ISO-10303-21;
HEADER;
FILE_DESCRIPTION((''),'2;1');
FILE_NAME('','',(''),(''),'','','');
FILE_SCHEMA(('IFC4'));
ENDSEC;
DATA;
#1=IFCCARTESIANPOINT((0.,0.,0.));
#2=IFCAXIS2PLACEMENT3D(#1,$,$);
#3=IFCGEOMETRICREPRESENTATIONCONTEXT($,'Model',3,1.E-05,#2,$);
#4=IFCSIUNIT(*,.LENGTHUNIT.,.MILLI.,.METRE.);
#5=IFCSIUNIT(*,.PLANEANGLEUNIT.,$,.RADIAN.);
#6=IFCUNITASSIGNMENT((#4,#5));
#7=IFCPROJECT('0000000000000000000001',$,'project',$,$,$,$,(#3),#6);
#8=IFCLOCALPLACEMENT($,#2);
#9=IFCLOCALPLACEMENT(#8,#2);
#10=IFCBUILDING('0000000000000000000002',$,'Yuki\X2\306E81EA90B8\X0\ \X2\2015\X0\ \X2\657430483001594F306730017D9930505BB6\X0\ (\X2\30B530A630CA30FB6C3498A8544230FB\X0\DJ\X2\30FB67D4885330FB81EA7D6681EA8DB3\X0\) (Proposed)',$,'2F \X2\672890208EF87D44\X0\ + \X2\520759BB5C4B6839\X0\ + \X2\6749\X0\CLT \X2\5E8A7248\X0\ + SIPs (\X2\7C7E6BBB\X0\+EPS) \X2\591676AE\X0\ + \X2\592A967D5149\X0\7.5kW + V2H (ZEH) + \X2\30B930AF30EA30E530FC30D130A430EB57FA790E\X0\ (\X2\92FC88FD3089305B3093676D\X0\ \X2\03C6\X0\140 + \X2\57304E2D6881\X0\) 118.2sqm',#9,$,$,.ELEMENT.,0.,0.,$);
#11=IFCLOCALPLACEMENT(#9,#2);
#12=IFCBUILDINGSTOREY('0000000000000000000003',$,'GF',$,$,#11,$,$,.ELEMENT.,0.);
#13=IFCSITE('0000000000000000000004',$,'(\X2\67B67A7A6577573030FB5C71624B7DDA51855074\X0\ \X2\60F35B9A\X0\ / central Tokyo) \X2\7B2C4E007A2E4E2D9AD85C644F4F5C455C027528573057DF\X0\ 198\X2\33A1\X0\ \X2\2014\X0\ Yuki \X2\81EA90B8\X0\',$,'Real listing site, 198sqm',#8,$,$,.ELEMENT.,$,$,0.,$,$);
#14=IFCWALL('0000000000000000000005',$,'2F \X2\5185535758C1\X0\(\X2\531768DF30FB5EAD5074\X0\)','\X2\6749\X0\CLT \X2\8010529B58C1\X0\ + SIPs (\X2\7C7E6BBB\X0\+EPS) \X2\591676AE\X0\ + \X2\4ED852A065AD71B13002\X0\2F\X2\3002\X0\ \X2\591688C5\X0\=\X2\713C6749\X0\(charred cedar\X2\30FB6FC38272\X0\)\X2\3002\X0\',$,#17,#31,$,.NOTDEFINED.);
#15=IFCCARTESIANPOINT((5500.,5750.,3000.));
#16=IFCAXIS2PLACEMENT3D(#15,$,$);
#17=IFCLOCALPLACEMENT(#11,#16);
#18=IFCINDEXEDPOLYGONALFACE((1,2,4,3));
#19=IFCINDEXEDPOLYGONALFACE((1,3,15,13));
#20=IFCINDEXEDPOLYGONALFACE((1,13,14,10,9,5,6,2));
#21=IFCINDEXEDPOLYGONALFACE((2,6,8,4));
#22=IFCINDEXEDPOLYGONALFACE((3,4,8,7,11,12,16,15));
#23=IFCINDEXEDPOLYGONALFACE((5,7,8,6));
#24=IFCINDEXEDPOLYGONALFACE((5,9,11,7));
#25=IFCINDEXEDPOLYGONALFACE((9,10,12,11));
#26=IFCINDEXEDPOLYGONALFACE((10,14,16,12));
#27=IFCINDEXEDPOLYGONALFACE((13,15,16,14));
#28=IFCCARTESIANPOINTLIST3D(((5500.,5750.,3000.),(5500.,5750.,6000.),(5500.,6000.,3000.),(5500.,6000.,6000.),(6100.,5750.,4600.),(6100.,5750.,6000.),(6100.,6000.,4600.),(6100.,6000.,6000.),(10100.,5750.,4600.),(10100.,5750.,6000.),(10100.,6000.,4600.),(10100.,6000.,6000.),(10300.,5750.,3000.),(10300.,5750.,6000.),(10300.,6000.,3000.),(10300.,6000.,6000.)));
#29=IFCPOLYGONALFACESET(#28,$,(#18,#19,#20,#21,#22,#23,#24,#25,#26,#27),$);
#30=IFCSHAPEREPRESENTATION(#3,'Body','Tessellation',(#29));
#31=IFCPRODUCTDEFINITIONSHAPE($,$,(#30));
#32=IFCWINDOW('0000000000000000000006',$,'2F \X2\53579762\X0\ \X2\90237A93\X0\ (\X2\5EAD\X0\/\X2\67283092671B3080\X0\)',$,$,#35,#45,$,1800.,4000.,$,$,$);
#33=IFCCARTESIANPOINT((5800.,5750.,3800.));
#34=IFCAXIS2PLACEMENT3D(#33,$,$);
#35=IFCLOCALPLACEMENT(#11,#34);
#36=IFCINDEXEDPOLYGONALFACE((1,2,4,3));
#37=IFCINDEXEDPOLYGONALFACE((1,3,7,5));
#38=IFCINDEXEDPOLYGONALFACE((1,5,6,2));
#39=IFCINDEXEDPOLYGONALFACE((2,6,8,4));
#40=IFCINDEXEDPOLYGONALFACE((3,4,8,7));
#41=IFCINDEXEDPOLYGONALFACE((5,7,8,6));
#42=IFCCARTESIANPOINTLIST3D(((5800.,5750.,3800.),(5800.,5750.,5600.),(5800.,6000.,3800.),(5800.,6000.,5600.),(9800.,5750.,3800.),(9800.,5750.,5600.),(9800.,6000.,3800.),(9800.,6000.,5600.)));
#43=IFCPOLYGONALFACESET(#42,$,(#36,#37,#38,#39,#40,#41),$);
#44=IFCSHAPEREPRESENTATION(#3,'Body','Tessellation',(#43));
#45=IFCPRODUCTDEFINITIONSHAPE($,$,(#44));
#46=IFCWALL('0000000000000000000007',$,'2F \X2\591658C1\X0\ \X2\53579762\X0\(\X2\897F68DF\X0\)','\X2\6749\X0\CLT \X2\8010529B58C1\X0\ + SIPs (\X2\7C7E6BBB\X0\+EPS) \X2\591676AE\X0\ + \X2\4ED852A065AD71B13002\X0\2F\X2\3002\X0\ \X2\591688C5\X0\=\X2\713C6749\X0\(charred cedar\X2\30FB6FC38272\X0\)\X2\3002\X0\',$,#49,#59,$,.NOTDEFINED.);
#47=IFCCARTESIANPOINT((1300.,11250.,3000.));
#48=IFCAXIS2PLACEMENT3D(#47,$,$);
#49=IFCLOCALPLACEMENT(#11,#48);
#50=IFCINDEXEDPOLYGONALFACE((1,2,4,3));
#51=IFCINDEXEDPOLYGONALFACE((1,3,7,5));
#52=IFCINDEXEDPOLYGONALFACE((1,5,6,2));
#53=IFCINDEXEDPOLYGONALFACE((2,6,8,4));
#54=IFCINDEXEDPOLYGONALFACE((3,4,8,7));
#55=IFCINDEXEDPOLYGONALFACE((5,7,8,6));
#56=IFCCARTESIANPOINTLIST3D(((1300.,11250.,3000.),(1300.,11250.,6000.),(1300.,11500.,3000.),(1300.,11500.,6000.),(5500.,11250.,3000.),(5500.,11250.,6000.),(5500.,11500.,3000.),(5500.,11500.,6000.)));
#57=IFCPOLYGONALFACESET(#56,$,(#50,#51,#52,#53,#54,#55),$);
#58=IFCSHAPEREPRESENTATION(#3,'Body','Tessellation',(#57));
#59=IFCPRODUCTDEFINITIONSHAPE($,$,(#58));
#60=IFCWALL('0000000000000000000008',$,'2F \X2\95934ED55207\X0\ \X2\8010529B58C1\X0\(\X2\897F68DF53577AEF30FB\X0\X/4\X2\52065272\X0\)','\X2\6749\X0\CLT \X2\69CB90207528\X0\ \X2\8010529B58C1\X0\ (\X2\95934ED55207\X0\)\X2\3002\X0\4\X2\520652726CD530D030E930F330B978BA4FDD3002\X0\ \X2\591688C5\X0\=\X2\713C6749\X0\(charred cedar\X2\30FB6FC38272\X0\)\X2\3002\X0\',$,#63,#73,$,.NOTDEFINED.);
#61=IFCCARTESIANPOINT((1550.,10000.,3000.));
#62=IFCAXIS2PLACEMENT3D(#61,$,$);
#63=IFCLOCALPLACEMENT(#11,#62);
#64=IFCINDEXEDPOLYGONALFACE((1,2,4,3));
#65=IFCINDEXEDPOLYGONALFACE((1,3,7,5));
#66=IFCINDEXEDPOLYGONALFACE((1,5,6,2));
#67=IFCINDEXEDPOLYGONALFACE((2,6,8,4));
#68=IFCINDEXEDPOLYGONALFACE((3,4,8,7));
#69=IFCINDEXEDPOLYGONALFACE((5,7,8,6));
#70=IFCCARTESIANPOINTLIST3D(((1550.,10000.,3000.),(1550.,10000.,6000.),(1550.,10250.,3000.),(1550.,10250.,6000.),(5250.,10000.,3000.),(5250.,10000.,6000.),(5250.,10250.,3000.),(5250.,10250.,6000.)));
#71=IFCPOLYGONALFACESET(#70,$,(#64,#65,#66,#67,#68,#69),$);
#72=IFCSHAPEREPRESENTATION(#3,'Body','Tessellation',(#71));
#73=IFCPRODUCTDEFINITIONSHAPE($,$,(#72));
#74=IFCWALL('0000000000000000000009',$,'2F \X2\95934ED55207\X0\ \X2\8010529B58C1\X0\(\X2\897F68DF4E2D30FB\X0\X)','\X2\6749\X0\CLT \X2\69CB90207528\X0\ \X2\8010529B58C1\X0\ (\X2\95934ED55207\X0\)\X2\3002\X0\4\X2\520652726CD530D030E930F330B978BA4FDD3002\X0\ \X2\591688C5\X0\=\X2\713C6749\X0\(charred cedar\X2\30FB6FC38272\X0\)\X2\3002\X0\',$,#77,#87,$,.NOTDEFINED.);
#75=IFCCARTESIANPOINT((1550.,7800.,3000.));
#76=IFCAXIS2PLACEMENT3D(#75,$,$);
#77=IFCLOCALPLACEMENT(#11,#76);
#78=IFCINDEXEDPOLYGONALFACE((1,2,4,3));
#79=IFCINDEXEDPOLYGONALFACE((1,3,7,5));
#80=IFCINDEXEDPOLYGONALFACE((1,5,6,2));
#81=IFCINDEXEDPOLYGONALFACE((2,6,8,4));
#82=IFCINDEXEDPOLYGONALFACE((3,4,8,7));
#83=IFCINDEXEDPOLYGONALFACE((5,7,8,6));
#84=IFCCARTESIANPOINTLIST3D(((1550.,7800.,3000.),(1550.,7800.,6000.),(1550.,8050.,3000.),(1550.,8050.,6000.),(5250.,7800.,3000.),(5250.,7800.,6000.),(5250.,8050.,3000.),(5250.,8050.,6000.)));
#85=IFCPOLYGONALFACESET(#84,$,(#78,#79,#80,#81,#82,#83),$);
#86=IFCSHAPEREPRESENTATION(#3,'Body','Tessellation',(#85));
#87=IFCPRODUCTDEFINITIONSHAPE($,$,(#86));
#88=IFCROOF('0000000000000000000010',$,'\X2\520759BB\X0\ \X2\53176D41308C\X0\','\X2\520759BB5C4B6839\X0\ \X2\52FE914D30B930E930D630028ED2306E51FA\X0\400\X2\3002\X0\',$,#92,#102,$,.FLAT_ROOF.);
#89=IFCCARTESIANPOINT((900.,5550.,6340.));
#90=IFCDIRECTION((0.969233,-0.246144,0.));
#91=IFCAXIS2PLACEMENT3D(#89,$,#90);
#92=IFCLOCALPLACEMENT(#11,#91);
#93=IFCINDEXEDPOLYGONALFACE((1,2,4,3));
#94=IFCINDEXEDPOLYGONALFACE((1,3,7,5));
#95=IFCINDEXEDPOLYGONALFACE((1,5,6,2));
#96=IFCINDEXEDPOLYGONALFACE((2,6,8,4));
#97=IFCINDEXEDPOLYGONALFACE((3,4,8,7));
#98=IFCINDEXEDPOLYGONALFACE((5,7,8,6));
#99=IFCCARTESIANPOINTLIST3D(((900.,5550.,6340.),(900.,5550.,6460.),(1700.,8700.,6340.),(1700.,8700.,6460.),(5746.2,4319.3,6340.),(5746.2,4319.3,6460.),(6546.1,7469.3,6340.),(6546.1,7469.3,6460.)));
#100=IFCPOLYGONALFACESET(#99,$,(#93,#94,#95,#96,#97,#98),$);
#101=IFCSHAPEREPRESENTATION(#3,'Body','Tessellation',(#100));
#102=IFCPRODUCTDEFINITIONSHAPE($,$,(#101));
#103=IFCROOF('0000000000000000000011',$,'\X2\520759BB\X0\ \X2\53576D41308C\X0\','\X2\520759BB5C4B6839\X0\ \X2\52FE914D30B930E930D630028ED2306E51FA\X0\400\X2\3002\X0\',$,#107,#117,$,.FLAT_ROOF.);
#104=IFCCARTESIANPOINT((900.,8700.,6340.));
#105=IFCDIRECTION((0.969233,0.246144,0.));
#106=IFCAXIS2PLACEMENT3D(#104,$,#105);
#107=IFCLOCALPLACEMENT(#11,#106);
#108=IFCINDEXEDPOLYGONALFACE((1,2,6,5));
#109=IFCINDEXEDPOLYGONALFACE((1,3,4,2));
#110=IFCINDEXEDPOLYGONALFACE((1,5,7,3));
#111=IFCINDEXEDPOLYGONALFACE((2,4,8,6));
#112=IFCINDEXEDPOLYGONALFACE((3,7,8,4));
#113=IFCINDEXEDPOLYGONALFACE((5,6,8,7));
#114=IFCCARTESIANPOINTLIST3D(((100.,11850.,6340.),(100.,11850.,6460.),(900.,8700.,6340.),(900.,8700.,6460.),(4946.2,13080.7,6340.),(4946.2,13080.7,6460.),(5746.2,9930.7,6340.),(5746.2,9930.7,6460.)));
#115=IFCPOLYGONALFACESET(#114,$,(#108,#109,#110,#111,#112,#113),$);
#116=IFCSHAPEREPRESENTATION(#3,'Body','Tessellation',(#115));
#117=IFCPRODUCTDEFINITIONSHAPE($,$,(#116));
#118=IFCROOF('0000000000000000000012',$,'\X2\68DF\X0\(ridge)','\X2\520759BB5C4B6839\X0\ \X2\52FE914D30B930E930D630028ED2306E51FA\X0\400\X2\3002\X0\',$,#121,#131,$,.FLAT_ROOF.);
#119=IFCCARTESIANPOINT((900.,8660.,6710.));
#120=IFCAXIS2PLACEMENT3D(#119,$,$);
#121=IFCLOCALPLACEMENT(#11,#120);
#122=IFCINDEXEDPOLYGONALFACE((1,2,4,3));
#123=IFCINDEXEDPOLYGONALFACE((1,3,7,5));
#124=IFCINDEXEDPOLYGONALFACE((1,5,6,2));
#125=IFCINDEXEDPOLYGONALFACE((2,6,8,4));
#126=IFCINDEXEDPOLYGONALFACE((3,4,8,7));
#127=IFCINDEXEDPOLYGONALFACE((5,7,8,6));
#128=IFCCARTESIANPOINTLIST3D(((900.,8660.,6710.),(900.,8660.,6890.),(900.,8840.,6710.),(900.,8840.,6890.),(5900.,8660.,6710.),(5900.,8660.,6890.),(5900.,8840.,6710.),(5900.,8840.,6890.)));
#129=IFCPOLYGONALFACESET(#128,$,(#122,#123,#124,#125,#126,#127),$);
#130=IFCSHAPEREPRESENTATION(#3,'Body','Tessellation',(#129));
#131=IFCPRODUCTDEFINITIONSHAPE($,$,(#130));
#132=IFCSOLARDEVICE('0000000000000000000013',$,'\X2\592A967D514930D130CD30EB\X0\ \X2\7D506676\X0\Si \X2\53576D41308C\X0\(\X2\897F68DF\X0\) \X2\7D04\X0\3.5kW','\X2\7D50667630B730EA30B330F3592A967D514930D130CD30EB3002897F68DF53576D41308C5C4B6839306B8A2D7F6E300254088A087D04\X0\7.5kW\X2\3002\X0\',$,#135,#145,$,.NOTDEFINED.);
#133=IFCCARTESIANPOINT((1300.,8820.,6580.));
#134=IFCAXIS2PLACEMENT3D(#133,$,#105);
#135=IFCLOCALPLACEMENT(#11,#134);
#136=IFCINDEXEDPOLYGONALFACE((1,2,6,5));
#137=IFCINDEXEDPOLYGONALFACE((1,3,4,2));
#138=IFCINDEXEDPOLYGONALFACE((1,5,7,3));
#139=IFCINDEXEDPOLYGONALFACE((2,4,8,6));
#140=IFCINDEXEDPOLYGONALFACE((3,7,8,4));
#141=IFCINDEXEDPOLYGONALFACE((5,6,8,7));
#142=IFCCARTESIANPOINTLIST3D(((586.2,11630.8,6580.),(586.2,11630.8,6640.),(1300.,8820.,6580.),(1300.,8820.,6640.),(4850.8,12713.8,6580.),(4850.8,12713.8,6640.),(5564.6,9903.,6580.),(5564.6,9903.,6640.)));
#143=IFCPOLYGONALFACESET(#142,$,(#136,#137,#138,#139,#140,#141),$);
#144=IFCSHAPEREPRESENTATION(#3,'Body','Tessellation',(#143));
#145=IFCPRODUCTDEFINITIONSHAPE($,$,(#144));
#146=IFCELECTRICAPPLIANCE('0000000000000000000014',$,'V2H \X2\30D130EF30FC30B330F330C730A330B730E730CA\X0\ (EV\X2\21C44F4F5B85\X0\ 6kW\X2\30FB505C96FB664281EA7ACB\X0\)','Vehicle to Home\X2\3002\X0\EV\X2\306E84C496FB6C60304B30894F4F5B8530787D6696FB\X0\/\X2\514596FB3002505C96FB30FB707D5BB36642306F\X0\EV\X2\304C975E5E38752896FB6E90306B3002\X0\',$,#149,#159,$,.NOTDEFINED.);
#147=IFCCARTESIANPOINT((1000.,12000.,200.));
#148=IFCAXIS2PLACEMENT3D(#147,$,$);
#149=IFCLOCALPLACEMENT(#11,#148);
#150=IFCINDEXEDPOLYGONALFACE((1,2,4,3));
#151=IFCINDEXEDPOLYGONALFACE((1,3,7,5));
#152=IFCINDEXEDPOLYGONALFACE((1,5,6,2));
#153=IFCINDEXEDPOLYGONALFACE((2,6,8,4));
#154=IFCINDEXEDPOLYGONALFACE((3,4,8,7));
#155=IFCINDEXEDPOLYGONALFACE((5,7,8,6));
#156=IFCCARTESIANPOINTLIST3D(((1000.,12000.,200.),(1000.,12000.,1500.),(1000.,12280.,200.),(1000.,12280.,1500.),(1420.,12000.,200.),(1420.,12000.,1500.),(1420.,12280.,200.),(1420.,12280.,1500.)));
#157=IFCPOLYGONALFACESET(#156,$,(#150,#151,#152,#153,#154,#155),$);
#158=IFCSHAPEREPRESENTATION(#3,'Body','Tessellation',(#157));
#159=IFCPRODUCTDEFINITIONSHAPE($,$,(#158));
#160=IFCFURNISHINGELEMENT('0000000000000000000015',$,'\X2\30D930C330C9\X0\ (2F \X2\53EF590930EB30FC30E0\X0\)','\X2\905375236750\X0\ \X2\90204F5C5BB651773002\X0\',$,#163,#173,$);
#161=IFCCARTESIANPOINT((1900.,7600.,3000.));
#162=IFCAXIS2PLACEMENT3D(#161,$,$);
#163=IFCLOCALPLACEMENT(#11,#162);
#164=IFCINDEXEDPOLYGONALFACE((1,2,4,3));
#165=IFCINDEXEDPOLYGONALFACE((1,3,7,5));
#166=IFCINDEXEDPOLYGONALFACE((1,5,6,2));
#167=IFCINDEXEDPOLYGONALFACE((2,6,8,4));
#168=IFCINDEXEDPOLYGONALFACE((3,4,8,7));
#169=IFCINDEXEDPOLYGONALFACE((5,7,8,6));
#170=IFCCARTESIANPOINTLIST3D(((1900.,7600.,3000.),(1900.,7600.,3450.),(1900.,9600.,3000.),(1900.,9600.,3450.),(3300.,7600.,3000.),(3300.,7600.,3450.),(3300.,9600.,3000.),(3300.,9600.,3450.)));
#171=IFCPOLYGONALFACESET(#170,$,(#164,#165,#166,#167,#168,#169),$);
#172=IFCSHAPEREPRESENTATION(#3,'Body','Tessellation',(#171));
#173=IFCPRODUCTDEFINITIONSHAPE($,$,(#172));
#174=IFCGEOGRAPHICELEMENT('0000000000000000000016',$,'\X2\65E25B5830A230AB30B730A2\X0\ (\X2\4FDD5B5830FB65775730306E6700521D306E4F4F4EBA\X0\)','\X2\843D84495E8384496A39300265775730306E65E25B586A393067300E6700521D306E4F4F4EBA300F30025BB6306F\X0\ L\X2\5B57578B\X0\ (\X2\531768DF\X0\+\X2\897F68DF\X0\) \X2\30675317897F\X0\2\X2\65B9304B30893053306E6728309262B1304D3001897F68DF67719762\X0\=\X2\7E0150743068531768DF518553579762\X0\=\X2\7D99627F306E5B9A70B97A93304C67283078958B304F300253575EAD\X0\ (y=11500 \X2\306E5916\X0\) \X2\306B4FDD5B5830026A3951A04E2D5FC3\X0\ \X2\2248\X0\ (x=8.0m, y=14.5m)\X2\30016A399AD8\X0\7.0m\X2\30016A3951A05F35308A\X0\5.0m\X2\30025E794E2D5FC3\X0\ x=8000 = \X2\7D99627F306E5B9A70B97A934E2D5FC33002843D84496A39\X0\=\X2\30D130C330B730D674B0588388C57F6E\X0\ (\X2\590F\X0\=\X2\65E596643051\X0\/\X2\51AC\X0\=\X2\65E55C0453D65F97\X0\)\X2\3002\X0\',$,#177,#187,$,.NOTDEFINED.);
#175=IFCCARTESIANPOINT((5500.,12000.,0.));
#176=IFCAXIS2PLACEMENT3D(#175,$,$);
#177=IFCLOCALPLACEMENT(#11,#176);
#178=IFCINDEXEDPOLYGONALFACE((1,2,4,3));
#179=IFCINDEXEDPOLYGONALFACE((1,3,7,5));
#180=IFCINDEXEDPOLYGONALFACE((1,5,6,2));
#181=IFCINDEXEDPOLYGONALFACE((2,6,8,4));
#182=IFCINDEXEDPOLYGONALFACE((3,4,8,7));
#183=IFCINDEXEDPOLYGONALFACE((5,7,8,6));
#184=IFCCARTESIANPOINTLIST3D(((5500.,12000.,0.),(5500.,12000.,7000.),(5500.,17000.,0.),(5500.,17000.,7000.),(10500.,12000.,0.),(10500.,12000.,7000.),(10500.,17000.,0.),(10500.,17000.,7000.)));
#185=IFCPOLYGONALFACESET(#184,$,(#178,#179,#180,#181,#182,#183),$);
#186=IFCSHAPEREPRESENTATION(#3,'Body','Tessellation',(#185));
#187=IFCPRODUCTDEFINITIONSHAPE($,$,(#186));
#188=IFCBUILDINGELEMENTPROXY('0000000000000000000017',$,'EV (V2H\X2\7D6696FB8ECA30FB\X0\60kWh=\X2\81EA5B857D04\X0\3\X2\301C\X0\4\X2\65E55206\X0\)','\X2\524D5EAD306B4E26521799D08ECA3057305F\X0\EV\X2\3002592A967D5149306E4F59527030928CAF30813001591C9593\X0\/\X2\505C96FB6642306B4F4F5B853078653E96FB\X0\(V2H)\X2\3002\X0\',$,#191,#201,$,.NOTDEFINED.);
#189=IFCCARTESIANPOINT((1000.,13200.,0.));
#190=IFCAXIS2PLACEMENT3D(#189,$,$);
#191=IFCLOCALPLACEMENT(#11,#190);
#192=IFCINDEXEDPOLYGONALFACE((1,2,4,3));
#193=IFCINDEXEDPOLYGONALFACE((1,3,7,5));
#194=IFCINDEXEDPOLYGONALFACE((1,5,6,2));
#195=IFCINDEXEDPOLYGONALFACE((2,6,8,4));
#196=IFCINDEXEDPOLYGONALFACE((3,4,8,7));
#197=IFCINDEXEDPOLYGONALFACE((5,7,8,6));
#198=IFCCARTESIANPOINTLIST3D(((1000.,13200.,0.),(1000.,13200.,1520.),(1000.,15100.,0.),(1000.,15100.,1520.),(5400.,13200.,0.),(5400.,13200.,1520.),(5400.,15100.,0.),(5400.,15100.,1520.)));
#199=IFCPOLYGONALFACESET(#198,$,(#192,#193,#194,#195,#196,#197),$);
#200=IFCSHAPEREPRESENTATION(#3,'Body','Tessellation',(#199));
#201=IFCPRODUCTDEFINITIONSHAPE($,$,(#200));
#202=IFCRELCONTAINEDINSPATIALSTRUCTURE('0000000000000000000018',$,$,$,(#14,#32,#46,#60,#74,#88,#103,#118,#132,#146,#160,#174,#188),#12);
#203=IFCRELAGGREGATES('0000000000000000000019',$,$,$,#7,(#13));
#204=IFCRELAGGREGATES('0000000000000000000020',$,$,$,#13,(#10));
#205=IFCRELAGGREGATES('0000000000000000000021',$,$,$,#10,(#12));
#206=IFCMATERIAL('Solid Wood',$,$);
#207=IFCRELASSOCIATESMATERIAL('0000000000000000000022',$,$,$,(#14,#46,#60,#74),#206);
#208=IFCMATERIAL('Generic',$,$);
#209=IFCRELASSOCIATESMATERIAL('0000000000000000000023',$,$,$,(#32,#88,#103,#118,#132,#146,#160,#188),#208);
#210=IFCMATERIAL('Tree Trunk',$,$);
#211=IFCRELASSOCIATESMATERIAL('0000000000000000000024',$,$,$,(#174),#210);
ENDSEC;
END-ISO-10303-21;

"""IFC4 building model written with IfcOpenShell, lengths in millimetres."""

from ifc_helpers import new_model, si_unit, frame, frame_2d, origin, place, context, project, spatial, rectangle, extrude, material, element, fill, save


model = new_model("IFC4")

# Units and contexts
model_context = context("Model", 3, precision=1e-05, world=origin())
ifc_project = project(units=[si_unit("LENGTHUNIT", "METRE", prefix="MILLI"), si_unit("PLANEANGLEUNIT", "RADIAN")], contexts=[model_context])

# Site, building, storey
site_placement = place(None, origin())
site = spatial("IfcSite", under=ifc_project, at=site_placement, Name="(架空敷地・山手線内側 想定 / central Tokyo) 第一種中高層住居専用地域 198㎡ — Yuki 自邸", ObjectType="Real listing site, 198sqm", CompositionType="ELEMENT", RefElevation=0.0)
building_placement = place(site_placement, origin())
building = spatial("IfcBuilding", under=site, at=building_placement, Name="Yukiの自邸 ― 整え、奏で、継ぐ家 (サウナ・水風呂・DJ・柔術・自給自足) (Proposed)", ObjectType="2F 木造軸組 + 切妻屋根 + 杉CLT 床版 + SIPs (籾殻+EPS) 外皮 + 太陽光7.5kW + V2H (ZEH) + スクリューパイル基礎 (鋼製らせん杭 φ140 + 地中梁) 118.2sqm", CompositionType="ELEMENT", ElevationOfRefHeight=0.0, ElevationOfTerrain=0.0)
storey_placement = place(building_placement, origin())
storey = spatial("IfcBuildingStorey", under=building, at=storey_placement, Name="GF", CompositionType="ELEMENT", Elevation=0.0)

# Shared definitions
ifc_material_1 = material(Name="Generic")

# Shared definitions
ifc_material_2 = material(Name="Solid Wood")
ifc_material_3 = material(Name="Tree Trunk")

# Wall, opening, window
wall_1_placement = place(storey_placement, frame((5500.0, 5750.0, 3000.0)))
wall_1 = element("IfcWall", 1, at=wall_1_placement, inside=storey, material=ifc_material_2, Name="2F 内南壁(北棟・庭側)", Description="杉CLT 耐力壁 + SIPs (籾殻+EPS) 外皮 + 付加断熱。2F。 外装=焼杉(charred cedar・濃色)。", PredefinedType="NOTDEFINED", context=model_context, shape_type="SweptSolid", body=[
    extrude(rectangle(XDim=4800.0, YDim=250.0, at=frame_2d((2400.0, 125.0))), frame((5500.0, 5750.0, 3000.0)), (0.0, 0.0, 1.0), 3000.0),
])
opening_1_placement = place(storey_placement, frame((5800.0, 5750.0, 3800.0)))
opening_1 = element("IfcOpeningElement", 2, at=opening_1_placement, cuts=wall_1, PredefinedType="NOTDEFINED", context=model_context, shape_type="SweptSolid", body=[
    extrude(rectangle(XDim=4000.0, YDim=250.0, at=frame_2d((2000.0, 125.0))), frame((5800.0, 5750.0, 3800.0)), (0.0, 0.0, 1.0), 1800.0),
])
window_1_placement = place(storey_placement, frame((5800.0, 5750.0, 3800.0)))
window_1 = element("IfcWindow", 3, at=window_1_placement, inside=storey, material=ifc_material_1, Name="2F 南面 連窓 (庭/木を望む)", OverallHeight=1800.0, OverallWidth=4000.0, context=model_context, shape_type="SweptSolid", body=[
    extrude(rectangle(XDim=4000.0, YDim=250.0, at=frame_2d((2000.0, 125.0))), frame((5800.0, 5750.0, 3800.0)), (0.0, 0.0, 1.0), 1800.0),
])
fill(opening_1, window_1)

# Walls
wall_2_placement = place(storey_placement, frame((1300.0, 11250.0, 3000.0)))
element("IfcWall", 4, at=wall_2_placement, inside=storey, material=ifc_material_2, Name="2F 外壁 南面(西棟)", Description="杉CLT 耐力壁 + SIPs (籾殻+EPS) 外皮 + 付加断熱。2F。 外装=焼杉(charred cedar・濃色)。", PredefinedType="NOTDEFINED", context=model_context, shape_type="SweptSolid", body=[
    extrude(rectangle(XDim=4200.0, YDim=250.0, at=frame_2d((2100.0, 125.0))), frame((1300.0, 11250.0, 3000.0)), (0.0, 0.0, 1.0), 3000.0),
])
wall_3_placement = place(storey_placement, frame((1550.0, 10000.0, 3000.0)))
element("IfcWall", 5, at=wall_3_placement, inside=storey, material=ifc_material_2, Name="2F 間仕切 耐力壁(西棟南端・X/4分割)", Description="杉CLT 構造用 耐力壁 (間仕切)。4分割法バランス確保。 外装=焼杉(charred cedar・濃色)。", PredefinedType="NOTDEFINED", context=model_context, shape_type="SweptSolid", body=[
    extrude(rectangle(XDim=3700.0, YDim=250.0, at=frame_2d((1850.0, 125.0))), frame((1550.0, 10000.0, 3000.0)), (0.0, 0.0, 1.0), 3000.0),
])
wall_4_placement = place(storey_placement, frame((1550.0, 7800.0, 3000.0)))
element("IfcWall", 6, at=wall_4_placement, inside=storey, material=ifc_material_2, Name="2F 間仕切 耐力壁(西棟中・X)", Description="杉CLT 構造用 耐力壁 (間仕切)。4分割法バランス確保。 外装=焼杉(charred cedar・濃色)。", PredefinedType="NOTDEFINED", context=model_context, shape_type="SweptSolid", body=[
    extrude(rectangle(XDim=3700.0, YDim=250.0, at=frame_2d((1850.0, 125.0))), frame((1550.0, 7800.0, 3000.0)), (0.0, 0.0, 1.0), 3000.0),
])

# Roofs
roof_1_placement = place(storey_placement, frame((900.0, 5550.0, 6340.0), x_axis=(0.969233, -0.246144, 0.0)))
element("IfcRoof", 7, at=roof_1_placement, inside=storey, material=ifc_material_1, Name="切妻 北流れ", Description="切妻屋根 勾配スラブ。軒の出400。", PredefinedType="FLAT_ROOF", context=model_context, shape_type="SweptSolid", body=[
    extrude(rectangle(XDim=5000.0, YDim=3250.0, at=frame_2d((2500.0, 1625.0))), frame((900.0, 5550.0, 6340.0), x_axis=(0.969233, -0.246144, 0.0)), (0.0, 0.0, 1.0), 120.0),
])
roof_2_placement = place(storey_placement, frame((900.0, 8700.0, 6340.0), x_axis=(0.969233, 0.246144, 0.0)))
element("IfcRoof", 8, at=roof_2_placement, inside=storey, material=ifc_material_1, Name="切妻 南流れ", Description="切妻屋根 勾配スラブ。軒の出400。", PredefinedType="FLAT_ROOF", context=model_context, shape_type="SweptSolid", body=[
    extrude(rectangle(XDim=5000.0, YDim=3250.0, at=frame_2d((2500.0, 1625.0))), frame((900.0, 8700.0, 6340.0), x_axis=(0.969233, 0.246144, 0.0)), (0.0, 0.0, 1.0), 120.0),
])
roof_3_placement = place(storey_placement, frame((900.0, 8660.0, 6710.0)))
element("IfcRoof", 9, at=roof_3_placement, inside=storey, material=ifc_material_1, Name="棟(ridge)", Description="切妻屋根 勾配スラブ。軒の出400。", PredefinedType="FLAT_ROOF", context=model_context, shape_type="SweptSolid", body=[
    extrude(rectangle(XDim=5000.0, YDim=180.0, at=frame_2d((2500.0, 90.0))), frame((900.0, 8660.0, 6710.0)), (0.0, 0.0, 1.0), 180.0),
])

# Solar device
solar_device_placement = place(storey_placement, frame((1300.0, 8820.0, 6580.0), x_axis=(0.969233, 0.246144, 0.0)))
element("IfcSolarDevice", 10, at=solar_device_placement, inside=storey, material=ifc_material_1, Name="太陽光パネル 結晶Si 南流れ(西棟) 約3.5kW", Description="結晶シリコン太陽光パネル。西棟南流れ屋根に設置。合計約7.5kW。", PredefinedType="NOTDEFINED", context=model_context, shape_type="SweptSolid", body=[
    extrude(rectangle(XDim=4400.0, YDim=2900.0, at=frame_2d((2200.0, 1450.0))), frame((1300.0, 8820.0, 6580.0), x_axis=(0.969233, 0.246144, 0.0)), (0.0, 0.0, 1.0), 60.0),
])

# Electric appliance
electric_appliance_placement = place(storey_placement, frame((1000.0, 12000.0, 200.0)))
element("IfcElectricAppliance", 11, at=electric_appliance_placement, inside=storey, material=ifc_material_1, Name="V2H パワーコンディショナ (EV⇄住宅 6kW・停電時自立)", Description="Vehicle to Home。EVの蓄電池から住宅へ給電/充電。停電・災害時はEVが非常用電源に。", PredefinedType="NOTDEFINED", context=model_context, shape_type="SweptSolid", body=[
    extrude(rectangle(XDim=420.0, YDim=280.0, at=frame_2d((210.0, 140.0))), frame((1000.0, 12000.0, 200.0)), (0.0, 0.0, 1.0), 1300.0),
])

# Furnishing element
furnishing_1_placement = place(storey_placement, frame((1900.0, 7600.0, 3000.0)))
element("IfcFurnishingElement", 12, at=furnishing_1_placement, inside=storey, material=ifc_material_1, Name="ベッド (2F 可変ルーム)", Description="道産材 造作家具。", context=model_context, shape_type="SweptSolid", body=[
    extrude(rectangle(XDim=1400.0, YDim=2000.0, at=frame_2d((700.0, 1000.0))), frame((1900.0, 7600.0, 3000.0)), (0.0, 0.0, 1.0), 450.0),
])

# Geographic element
geographic_element_placement = place(storey_placement, frame((5500.0, 12000.0, 0.0)))
element("IfcGeographicElement", 13, at=geographic_element_placement, inside=storey, material=ifc_material_3, Name="既存アカシア (保存・敷地の最初の住人)", Description="落葉広葉樹。敷地の既存樹で『最初の住人』。家は L字型 (北棟+西棟) で北西2方からこの木を抱き、西棟東面=縁側と北棟内南面=継承の定点窓が木へ開く。南庭 (y=11500 の外) に保存。樹冠中心 ≈ (x=8.0m, y=14.5m)、樹高7.0m、樹冠張り5.0m。幹中心 x=8000 = 継承の定点窓中心。落葉樹=パッシブ環境装置 (夏=日除け/冬=日射取得)。", PredefinedType="NOTDEFINED", context=model_context, shape_type="SweptSolid", body=[
    extrude(rectangle(XDim=5000.0, YDim=5000.0, at=frame_2d((2500.0, 2500.0))), frame((5500.0, 12000.0, 0.0)), (0.0, 0.0, 1.0), 7000.0),
])

# Building element proxy
proxy_placement = place(storey_placement, frame((1000.0, 13200.0, 0.0)))
element("IfcBuildingElementProxy", 14, at=proxy_placement, inside=storey, material=ifc_material_1, Name="EV (V2H給電車・60kWh=自宅約3〜4日分)", Description="前庭に並列駐車したEV。太陽光の余剰を貯め、夜間/停電時に住宅へ放電(V2H)。", PredefinedType="NOTDEFINED", context=model_context, shape_type="SweptSolid", body=[
    extrude(rectangle(XDim=4400.0, YDim=1900.0, at=frame_2d((2200.0, 950.0))), frame((1000.0, 13200.0, 0.0)), (0.0, 0.0, 1.0), 1520.0),
])

save(model, "model.ifc")
